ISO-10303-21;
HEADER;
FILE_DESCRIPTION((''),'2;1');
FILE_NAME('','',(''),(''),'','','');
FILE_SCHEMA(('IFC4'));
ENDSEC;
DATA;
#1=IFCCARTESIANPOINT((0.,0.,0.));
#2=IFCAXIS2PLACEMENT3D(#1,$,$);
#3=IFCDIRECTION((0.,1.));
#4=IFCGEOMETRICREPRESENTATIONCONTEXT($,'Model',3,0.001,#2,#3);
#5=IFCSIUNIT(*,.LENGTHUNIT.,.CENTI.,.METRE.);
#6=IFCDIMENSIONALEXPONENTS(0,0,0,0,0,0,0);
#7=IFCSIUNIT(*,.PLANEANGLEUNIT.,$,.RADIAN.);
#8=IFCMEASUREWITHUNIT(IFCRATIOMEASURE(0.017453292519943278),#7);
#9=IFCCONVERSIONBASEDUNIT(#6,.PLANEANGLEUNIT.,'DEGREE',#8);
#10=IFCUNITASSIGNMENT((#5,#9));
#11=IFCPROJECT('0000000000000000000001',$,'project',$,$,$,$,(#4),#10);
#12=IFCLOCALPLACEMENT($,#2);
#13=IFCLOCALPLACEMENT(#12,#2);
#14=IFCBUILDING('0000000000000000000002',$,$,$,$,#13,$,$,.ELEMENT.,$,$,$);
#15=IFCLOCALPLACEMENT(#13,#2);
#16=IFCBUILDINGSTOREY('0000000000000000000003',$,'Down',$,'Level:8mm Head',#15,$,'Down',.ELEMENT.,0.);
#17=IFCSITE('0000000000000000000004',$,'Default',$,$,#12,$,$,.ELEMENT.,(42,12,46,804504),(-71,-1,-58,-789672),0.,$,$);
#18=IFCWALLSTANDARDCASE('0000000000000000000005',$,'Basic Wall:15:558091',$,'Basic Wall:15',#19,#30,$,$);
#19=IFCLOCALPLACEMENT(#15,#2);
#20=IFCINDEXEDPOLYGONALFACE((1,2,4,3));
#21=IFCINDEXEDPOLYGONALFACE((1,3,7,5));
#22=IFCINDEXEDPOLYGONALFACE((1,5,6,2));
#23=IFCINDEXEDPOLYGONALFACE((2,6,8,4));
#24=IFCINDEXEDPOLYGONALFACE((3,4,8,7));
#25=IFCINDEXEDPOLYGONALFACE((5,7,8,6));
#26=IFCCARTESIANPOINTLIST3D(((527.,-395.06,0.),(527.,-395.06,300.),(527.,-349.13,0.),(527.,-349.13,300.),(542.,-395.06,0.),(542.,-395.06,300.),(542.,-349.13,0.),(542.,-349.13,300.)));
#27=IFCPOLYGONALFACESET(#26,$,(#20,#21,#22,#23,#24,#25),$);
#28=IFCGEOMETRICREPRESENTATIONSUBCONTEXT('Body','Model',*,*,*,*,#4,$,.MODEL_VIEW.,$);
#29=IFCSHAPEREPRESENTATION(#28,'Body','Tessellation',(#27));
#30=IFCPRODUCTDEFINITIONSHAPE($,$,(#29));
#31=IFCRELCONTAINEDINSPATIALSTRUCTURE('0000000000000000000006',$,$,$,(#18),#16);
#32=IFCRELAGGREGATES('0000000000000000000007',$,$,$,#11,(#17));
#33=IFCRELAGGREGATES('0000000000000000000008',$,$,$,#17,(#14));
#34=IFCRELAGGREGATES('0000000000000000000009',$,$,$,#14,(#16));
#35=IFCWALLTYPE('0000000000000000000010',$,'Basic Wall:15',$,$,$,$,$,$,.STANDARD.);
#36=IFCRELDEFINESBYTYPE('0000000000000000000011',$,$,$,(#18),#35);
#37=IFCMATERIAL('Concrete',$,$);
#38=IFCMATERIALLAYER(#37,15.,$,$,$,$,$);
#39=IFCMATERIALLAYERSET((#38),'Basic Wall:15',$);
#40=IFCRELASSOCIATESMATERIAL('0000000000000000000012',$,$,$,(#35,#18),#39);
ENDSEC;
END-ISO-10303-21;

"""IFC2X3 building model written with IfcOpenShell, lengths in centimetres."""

from ifc_helpers import new_model, entity, si_unit, converted_unit, direction, frame, frame_2d, origin, place, context, subcontext, project, spatial, rectangle, extrude, material, layer, layer_set, layer_usage, type_object, element, save


model = new_model("IFC2X3")

# Units and contexts
model_context = context("Model", 3, precision=0.001, world=origin(), true_north=direction((0.0, 1.0)))
body_context = subcontext(model_context, "Body", "Model", "MODEL_VIEW")
ifc_project = project(units=[si_unit("LENGTHUNIT", "METRE", prefix="CENTI"), converted_unit("PLANEANGLEUNIT", "DEGREE", entity("IfcRatioMeasure", 0.017453292519943278), si_unit("PLANEANGLEUNIT", "RADIAN"), dimensions=[0, 0, 0, 0, 0, 0, 0])], contexts=[model_context])

# Site, building, storey
site_placement = place(None, origin())
site = spatial("IfcSite", under=ifc_project, at=site_placement, Name="Default", CompositionType="ELEMENT", RefLatitude=(42, 12, 46, 804504), RefLongitude=(-71, -1, -58, -789672), RefElevation=0.0)
building_placement = place(site_placement, origin())
building = spatial("IfcBuilding", under=site, at=building_placement, CompositionType="ELEMENT")
storey_placement = place(building_placement, origin())
storey = spatial("IfcBuildingStorey", under=building, at=storey_placement, Name="Down", ObjectType="Level:8mm Head", LongName="Down", CompositionType="ELEMENT", Elevation=0.0)

# Wall
ifc_material = material(Name="Concrete")
ifc_layer_1 = layer(ifc_material, 15.0)
ifc_layer_set_1 = layer_set([ifc_layer_1], Name="Basic Wall:15")
wall_type_1 = type_object("IfcWallType", Name="Basic Wall:15", PredefinedType="STANDARD", material=ifc_layer_set_1)
ifc_layer_usage_1 = layer_usage(ifc_layer_set_1, "AXIS2", "NEGATIVE", 7.5)
wall_1_placement = place(storey_placement, frame((534.5, -395.06, 0.0), z_axis=(0.0, 0.0, 1.0), x_axis=(0.0, 1.0, 0.0)))
element("IfcWallStandardCase", 1, at=wall_1_placement, inside=storey, type_object=wall_type_1, material=ifc_layer_usage_1, Name="Basic Wall:15:558091", ObjectType="Basic Wall:15", context=body_context, shape_type="SweptSolid", body=[
    extrude(rectangle(XDim=45.93, YDim=15.0, at=frame_2d((22.96, 0.0), x_axis=(-1.0, 0.0))), origin(), (0.0, 0.0, 1.0), 300.0),
])

save(model, "model.ifc")
